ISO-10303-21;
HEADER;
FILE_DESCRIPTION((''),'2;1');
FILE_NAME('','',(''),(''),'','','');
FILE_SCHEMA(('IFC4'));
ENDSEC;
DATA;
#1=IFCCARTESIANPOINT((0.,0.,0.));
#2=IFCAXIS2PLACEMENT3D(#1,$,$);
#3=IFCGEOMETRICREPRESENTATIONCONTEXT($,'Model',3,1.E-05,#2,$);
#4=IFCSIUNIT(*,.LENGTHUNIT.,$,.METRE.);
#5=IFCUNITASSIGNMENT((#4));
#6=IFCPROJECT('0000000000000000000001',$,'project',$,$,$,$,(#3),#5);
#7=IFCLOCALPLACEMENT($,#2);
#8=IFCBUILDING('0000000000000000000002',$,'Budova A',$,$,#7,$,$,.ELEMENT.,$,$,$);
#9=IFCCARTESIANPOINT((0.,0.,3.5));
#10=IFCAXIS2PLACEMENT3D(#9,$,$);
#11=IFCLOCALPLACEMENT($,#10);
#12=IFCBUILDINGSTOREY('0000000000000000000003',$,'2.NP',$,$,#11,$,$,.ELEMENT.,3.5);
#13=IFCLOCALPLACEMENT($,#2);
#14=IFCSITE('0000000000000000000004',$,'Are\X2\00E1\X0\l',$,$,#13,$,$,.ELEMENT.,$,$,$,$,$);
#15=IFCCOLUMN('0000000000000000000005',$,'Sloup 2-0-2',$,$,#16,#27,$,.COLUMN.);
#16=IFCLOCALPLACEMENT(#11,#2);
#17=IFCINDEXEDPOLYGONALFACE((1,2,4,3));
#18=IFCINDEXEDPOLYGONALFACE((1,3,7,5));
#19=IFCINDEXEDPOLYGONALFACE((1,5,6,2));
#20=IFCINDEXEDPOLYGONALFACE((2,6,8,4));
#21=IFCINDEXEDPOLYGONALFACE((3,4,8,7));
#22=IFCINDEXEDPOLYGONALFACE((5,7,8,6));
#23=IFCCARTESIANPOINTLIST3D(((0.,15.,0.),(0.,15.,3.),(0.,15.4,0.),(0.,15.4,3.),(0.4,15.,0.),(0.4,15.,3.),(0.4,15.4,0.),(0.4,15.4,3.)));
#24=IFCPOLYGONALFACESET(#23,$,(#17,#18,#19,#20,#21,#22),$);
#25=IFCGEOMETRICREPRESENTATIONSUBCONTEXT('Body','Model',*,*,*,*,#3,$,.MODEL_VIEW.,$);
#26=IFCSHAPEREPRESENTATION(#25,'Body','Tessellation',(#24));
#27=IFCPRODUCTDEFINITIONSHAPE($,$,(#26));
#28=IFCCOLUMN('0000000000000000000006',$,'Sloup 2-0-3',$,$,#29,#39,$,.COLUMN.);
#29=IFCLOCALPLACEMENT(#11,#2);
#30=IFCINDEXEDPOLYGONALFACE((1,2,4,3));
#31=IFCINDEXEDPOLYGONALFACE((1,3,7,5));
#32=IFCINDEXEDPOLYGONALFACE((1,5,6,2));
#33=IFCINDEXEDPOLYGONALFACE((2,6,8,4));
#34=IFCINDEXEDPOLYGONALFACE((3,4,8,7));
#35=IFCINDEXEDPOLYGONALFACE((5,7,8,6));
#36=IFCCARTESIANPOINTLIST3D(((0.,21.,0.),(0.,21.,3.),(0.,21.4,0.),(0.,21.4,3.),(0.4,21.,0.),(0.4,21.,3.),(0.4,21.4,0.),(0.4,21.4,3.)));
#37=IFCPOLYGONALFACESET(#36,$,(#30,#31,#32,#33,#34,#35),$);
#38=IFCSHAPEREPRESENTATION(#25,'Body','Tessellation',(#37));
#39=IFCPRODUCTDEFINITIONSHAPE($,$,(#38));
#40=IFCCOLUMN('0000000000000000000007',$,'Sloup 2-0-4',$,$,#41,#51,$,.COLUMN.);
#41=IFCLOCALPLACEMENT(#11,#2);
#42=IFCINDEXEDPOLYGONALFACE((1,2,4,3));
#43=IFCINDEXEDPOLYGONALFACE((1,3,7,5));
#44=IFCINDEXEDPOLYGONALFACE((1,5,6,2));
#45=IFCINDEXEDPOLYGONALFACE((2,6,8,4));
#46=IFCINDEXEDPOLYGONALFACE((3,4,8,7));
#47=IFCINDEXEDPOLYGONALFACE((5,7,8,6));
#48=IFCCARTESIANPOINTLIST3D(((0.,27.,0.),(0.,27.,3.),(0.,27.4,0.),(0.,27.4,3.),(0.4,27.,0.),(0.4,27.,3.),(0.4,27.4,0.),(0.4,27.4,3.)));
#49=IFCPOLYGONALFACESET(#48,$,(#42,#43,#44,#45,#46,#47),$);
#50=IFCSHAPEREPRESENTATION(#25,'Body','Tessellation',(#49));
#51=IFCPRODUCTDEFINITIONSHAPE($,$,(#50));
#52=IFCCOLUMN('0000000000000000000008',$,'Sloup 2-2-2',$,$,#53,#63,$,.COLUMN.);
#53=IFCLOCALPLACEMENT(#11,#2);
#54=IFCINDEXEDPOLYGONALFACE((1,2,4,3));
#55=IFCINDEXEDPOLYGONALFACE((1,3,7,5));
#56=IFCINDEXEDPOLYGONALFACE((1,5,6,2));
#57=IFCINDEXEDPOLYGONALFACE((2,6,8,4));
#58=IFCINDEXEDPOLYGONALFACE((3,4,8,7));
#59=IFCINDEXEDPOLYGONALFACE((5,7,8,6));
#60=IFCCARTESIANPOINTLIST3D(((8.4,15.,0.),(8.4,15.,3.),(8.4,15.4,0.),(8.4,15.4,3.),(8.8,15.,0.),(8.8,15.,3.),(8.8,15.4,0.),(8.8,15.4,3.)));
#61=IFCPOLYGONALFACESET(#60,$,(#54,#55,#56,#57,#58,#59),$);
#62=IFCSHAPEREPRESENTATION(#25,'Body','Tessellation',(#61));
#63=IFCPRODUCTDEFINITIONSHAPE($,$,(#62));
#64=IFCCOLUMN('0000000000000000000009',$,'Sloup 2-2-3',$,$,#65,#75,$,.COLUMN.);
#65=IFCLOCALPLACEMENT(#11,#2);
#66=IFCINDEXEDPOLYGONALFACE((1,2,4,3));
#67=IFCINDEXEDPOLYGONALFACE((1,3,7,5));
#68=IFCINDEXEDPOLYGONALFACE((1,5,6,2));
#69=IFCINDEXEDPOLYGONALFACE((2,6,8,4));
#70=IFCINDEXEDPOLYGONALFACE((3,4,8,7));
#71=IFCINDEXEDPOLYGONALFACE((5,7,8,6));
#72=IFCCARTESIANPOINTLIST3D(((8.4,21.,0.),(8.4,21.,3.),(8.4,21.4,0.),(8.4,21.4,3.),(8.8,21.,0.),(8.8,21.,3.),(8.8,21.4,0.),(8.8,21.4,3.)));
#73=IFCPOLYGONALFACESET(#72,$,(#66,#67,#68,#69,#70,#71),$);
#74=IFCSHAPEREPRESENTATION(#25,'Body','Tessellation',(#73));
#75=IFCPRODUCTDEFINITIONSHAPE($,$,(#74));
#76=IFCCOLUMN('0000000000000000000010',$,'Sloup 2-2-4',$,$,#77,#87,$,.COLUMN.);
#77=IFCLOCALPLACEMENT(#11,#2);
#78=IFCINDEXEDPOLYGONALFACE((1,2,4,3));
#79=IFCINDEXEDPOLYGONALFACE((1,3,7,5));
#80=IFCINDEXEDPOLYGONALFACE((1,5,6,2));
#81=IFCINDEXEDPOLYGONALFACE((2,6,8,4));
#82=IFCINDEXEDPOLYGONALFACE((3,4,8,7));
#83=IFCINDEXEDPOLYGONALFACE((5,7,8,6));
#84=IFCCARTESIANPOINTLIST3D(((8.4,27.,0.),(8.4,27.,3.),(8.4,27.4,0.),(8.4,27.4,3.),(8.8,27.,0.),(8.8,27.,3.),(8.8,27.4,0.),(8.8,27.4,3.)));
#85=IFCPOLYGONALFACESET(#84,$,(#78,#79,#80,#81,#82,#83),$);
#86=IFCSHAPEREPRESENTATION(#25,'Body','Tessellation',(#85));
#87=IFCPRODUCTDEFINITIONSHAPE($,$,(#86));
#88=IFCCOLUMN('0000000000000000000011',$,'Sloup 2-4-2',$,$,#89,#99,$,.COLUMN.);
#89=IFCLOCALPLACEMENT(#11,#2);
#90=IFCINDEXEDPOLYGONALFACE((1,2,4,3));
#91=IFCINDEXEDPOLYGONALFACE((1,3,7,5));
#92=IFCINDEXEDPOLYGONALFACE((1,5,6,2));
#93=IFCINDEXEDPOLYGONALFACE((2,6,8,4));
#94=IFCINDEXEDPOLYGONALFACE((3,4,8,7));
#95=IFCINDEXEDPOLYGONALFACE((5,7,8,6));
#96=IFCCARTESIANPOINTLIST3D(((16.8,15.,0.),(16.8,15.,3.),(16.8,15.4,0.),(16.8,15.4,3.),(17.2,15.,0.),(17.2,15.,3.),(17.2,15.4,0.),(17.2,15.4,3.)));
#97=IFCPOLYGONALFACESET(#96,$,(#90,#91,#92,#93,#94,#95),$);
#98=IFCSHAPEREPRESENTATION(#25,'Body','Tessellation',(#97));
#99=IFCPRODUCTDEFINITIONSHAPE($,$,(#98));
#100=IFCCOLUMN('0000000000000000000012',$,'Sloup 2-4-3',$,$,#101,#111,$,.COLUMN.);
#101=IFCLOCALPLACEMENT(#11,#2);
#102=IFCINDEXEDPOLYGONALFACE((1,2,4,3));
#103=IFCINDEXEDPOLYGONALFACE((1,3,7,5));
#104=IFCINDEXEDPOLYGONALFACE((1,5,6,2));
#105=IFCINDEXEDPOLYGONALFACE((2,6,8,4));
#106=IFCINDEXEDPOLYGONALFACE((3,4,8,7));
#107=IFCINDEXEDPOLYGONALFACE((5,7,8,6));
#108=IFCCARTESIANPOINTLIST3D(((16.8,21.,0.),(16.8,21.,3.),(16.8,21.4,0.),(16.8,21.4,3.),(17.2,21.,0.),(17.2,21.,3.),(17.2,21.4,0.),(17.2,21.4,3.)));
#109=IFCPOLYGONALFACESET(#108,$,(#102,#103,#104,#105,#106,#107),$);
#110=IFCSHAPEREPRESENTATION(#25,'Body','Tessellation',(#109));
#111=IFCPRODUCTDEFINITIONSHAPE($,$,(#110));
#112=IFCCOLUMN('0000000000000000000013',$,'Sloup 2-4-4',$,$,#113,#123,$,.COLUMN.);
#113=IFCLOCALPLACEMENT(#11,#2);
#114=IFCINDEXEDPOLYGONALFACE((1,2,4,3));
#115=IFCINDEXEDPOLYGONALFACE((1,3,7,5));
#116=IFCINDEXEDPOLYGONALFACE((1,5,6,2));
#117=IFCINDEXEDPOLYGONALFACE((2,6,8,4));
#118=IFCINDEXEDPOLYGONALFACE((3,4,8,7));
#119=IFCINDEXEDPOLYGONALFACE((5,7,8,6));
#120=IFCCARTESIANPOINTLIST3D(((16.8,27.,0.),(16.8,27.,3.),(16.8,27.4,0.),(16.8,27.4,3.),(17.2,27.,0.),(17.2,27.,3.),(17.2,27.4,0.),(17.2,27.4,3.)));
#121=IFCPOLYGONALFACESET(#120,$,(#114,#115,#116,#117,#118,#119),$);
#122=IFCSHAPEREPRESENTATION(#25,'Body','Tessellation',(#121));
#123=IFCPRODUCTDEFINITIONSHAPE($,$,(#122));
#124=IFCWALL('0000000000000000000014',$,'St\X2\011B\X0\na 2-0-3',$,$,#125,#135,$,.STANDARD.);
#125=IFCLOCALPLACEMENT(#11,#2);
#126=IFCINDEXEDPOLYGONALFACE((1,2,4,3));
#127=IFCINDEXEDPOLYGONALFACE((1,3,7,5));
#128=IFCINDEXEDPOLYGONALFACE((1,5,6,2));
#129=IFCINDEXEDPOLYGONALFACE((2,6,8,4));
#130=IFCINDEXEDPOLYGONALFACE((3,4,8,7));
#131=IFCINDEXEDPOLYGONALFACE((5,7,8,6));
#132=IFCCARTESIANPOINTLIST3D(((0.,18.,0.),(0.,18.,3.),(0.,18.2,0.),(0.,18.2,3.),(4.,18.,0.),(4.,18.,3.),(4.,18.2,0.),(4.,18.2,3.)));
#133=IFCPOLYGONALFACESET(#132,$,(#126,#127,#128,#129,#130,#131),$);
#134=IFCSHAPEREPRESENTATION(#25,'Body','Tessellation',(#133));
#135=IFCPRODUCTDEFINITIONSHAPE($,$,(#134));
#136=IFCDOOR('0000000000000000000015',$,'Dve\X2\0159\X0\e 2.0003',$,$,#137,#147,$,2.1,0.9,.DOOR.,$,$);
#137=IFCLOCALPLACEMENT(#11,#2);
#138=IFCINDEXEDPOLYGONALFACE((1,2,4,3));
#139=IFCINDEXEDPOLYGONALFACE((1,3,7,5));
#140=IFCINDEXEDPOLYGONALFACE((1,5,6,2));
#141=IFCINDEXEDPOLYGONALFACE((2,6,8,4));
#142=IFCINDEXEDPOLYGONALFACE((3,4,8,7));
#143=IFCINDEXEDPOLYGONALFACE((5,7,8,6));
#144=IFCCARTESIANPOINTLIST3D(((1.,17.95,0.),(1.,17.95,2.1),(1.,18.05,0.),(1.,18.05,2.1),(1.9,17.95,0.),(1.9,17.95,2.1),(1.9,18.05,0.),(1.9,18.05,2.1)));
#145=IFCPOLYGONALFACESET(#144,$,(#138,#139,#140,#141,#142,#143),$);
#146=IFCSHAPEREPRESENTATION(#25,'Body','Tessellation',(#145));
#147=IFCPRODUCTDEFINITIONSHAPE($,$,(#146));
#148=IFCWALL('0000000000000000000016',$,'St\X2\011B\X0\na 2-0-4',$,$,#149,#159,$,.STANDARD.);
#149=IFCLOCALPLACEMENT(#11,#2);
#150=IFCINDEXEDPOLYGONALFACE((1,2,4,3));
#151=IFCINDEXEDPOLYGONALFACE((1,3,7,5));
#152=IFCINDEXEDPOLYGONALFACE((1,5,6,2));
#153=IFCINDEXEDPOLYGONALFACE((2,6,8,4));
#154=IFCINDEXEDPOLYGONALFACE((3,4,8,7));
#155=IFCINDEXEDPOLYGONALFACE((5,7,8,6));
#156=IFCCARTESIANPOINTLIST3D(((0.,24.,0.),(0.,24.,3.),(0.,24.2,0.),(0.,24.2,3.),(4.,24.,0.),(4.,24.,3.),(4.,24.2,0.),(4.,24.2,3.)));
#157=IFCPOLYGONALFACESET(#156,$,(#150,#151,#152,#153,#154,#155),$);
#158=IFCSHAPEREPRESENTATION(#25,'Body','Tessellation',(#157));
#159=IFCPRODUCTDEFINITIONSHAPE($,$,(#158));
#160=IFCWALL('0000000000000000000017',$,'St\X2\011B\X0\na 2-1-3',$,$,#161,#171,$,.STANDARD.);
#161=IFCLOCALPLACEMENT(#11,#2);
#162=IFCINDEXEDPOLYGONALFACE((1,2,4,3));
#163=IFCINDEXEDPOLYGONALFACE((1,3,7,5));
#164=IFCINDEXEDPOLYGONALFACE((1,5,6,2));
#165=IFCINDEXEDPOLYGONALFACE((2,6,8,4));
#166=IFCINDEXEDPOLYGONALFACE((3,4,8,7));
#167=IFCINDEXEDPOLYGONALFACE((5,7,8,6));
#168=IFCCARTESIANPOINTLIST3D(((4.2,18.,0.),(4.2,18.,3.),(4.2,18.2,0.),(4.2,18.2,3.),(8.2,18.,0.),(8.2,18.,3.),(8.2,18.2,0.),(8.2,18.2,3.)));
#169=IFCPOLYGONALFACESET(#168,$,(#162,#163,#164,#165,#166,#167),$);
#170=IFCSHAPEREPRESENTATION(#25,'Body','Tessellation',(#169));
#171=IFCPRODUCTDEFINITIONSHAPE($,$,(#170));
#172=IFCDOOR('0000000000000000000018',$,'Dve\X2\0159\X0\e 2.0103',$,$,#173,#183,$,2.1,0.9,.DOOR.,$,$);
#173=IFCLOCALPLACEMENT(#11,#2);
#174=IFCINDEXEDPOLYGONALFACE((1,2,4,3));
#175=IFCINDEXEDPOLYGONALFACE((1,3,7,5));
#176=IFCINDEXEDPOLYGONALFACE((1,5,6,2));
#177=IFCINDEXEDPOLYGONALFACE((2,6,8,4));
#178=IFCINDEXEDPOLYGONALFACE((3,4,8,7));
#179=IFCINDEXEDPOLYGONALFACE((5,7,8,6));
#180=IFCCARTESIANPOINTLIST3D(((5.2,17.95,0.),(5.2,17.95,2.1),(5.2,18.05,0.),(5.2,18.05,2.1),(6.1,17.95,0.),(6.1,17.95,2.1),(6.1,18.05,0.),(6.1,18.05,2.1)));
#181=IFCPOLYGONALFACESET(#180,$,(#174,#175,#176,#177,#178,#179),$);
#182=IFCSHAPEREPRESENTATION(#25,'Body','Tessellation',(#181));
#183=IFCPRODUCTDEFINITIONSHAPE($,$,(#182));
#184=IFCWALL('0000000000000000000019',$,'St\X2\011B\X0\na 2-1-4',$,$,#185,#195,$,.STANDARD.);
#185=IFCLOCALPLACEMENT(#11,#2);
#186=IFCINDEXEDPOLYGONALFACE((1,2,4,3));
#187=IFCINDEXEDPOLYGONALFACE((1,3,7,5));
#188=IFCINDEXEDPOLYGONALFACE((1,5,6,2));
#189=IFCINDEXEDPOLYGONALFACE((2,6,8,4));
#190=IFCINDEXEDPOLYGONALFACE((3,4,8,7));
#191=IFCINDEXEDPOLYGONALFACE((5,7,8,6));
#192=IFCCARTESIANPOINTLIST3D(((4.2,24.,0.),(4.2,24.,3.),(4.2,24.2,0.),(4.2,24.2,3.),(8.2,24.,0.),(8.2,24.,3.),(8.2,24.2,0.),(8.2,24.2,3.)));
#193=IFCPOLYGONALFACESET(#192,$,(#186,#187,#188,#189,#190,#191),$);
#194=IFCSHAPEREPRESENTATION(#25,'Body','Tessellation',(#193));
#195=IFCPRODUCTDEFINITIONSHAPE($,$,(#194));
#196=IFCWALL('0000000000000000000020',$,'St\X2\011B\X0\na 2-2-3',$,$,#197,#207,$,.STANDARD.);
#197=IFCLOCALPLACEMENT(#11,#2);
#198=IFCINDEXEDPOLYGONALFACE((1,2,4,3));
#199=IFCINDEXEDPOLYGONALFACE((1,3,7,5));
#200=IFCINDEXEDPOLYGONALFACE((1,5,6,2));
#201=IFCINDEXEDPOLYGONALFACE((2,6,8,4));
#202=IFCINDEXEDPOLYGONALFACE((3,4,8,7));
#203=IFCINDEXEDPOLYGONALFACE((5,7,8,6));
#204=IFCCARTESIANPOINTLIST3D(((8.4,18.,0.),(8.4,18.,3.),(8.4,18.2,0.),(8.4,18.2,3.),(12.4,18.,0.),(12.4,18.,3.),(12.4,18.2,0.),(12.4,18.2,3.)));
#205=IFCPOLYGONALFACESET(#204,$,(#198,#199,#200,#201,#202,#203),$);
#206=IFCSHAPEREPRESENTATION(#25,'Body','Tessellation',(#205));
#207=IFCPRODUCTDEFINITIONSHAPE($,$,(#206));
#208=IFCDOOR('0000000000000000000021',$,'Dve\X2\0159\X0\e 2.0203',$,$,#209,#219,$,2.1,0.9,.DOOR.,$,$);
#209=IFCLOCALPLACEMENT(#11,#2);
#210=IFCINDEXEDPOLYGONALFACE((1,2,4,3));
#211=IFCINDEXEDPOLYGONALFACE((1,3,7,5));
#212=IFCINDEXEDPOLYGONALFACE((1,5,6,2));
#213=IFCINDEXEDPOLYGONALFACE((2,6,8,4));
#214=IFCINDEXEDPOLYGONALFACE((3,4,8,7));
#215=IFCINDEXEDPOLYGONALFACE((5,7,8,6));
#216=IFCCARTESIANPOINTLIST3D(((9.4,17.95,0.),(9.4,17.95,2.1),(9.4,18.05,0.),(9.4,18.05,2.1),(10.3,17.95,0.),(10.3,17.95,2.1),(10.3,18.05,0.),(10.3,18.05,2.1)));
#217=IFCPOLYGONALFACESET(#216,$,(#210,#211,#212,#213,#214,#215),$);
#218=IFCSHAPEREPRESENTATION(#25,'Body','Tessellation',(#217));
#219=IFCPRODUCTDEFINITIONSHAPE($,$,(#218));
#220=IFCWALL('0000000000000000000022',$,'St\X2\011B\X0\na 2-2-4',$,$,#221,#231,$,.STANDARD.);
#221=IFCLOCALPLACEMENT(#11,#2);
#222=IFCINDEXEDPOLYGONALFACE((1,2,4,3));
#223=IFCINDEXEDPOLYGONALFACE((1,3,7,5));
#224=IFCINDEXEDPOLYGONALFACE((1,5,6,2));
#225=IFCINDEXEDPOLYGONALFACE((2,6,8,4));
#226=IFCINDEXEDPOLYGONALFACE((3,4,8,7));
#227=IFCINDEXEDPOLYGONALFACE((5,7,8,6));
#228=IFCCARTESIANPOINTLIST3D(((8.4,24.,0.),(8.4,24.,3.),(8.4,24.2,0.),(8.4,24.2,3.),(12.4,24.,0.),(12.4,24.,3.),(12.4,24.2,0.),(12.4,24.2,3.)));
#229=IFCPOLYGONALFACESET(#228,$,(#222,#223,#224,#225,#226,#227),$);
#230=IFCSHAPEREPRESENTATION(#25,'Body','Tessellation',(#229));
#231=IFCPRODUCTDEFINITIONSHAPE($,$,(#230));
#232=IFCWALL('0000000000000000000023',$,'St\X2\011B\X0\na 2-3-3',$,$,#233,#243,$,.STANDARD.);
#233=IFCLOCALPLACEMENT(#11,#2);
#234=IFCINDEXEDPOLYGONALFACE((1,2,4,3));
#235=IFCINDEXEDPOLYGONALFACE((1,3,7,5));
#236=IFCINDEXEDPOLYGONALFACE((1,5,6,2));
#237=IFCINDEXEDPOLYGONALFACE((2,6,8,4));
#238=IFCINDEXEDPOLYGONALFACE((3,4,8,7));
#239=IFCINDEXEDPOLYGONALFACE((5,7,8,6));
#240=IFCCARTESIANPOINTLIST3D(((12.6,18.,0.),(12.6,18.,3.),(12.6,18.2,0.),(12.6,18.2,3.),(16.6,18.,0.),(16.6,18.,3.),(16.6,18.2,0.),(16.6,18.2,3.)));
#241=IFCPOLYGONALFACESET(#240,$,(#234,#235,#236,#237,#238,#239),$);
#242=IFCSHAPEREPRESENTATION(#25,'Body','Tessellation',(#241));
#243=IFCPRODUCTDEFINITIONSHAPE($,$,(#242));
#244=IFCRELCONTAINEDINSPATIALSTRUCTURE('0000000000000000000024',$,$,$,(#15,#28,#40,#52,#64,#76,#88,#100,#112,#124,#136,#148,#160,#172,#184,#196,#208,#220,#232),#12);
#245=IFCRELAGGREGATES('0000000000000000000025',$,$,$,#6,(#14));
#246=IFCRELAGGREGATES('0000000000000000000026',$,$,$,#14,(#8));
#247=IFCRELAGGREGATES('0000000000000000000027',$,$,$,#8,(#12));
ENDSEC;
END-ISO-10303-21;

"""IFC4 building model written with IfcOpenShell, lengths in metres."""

from ifc_helpers import new_model, si_unit, frame, frame_2d, origin, place, context, subcontext, project, spatial, rectangle, extrude, element, save


model = new_model("IFC4")

# Units and contexts
model_context = context("Model", 3, precision=1e-05, world=origin())
body_context = subcontext(model_context, "Body", "Model", "MODEL_VIEW")
ifc_project = project(units=[si_unit("LENGTHUNIT", "METRE")], contexts=[model_context])

# Site, building, storey
site_placement = place(None, origin())
site = spatial("IfcSite", under=ifc_project, at=site_placement, Name="Areál", CompositionType="ELEMENT")
building_placement = place(None, origin())
building = spatial("IfcBuilding", under=site, at=building_placement, Name="Budova A", CompositionType="ELEMENT")
storey_placement = place(None, frame((0.0, 0.0, 3.5)))
storey = spatial("IfcBuildingStorey", under=building, at=storey_placement, Name="2.NP", CompositionType="ELEMENT", Elevation=3.5)

# Columns
for number, where, name in (
    (1, (0.0, 15.0, 0.0), "Sloup 2-0-2"),
    (2, (0.0, 21.0, 0.0), "Sloup 2-0-3"),
    (3, (0.0, 27.0, 0.0), "Sloup 2-0-4"),
    (4, (8.4, 15.0, 0.0), "Sloup 2-2-2"),
    (5, (8.4, 21.0, 0.0), "Sloup 2-2-3"),
    (6, (8.4, 27.0, 0.0), "Sloup 2-2-4"),
    (7, (16.8, 15.0, 0.0), "Sloup 2-4-2"),
    (8, (16.8, 21.0, 0.0), "Sloup 2-4-3"),
    (9, (16.8, 27.0, 0.0), "Sloup 2-4-4"),
):
    element("IfcColumn", number, at=place(storey_placement, frame(where)), inside=storey, Name=name, PredefinedType="COLUMN", context=body_context, shape_type="SweptSolid", body=[
        extrude(rectangle(XDim=0.4, YDim=0.4, at=frame_2d((0.2, 0.2))), origin(), (0.0, 0.0, 1.0), 3.0),
    ])

# Wall
wall_1_placement = place(storey_placement, frame((0.0, 18.0, 0.0)))
element("IfcWall", 10, at=wall_1_placement, inside=storey, Name="Stěna 2-0-3", PredefinedType="STANDARD", context=body_context, shape_type="SweptSolid", body=[
    extrude(rectangle(XDim=4.0, YDim=0.2, at=frame_2d((2.0, 0.1))), origin(), (0.0, 0.0, 1.0), 3.0),
])

# Door
door_1_placement = place(storey_placement, frame((1.0, 17.95, 0.0)))
element("IfcDoor", 11, at=door_1_placement, inside=storey, Name="Dveře 2.0003", OverallHeight=2.1, OverallWidth=0.9, PredefinedType="DOOR", context=body_context, shape_type="SweptSolid", body=[
    extrude(rectangle(XDim=0.9, YDim=0.1, at=frame_2d((0.45, 0.05))), origin(), (0.0, 0.0, 1.0), 2.1),
])

# Walls
for number, where, name in (
    (12, (0.0, 24.0, 0.0), "Stěna 2-0-4"),
    (13, (4.2, 18.0, 0.0), "Stěna 2-1-3"),
):
    element("IfcWall", number, at=place(storey_placement, frame(where)), inside=storey, Name=name, PredefinedType="STANDARD", context=body_context, shape_type="SweptSolid", body=[
        extrude(rectangle(XDim=4.0, YDim=0.2, at=frame_2d((2.0, 0.1))), origin(), (0.0, 0.0, 1.0), 3.0),
    ])

# Door
door_2_placement = place(storey_placement, frame((5.2, 17.95, 0.0)))
element("IfcDoor", 14, at=door_2_placement, inside=storey, Name="Dveře 2.0103", OverallHeight=2.1, OverallWidth=0.9, PredefinedType="DOOR", context=body_context, shape_type="SweptSolid", body=[
    extrude(rectangle(XDim=0.9, YDim=0.1, at=frame_2d((0.45, 0.05))), origin(), (0.0, 0.0, 1.0), 2.1),
])

# Walls
for number, where, name in (
    (15, (4.2, 24.0, 0.0), "Stěna 2-1-4"),
    (16, (8.4, 18.0, 0.0), "Stěna 2-2-3"),
):
    element("IfcWall", number, at=place(storey_placement, frame(where)), inside=storey, Name=name, PredefinedType="STANDARD", context=body_context, shape_type="SweptSolid", body=[
        extrude(rectangle(XDim=4.0, YDim=0.2, at=frame_2d((2.0, 0.1))), origin(), (0.0, 0.0, 1.0), 3.0),
    ])

# Door
door_3_placement = place(storey_placement, frame((9.4, 17.95, 0.0)))
element("IfcDoor", 17, at=door_3_placement, inside=storey, Name="Dveře 2.0203", OverallHeight=2.1, OverallWidth=0.9, PredefinedType="DOOR", context=body_context, shape_type="SweptSolid", body=[
    extrude(rectangle(XDim=0.9, YDim=0.1, at=frame_2d((0.45, 0.05))), origin(), (0.0, 0.0, 1.0), 2.1),
])

# Walls
for number, where, name in (
    (18, (8.4, 24.0, 0.0), "Stěna 2-2-4"),
    (19, (12.6, 18.0, 0.0), "Stěna 2-3-3"),
):
    element("IfcWall", number, at=place(storey_placement, frame(where)), inside=storey, Name=name, PredefinedType="STANDARD", context=body_context, shape_type="SweptSolid", body=[
        extrude(rectangle(XDim=4.0, YDim=0.2, at=frame_2d((2.0, 0.1))), origin(), (0.0, 0.0, 1.0), 3.0),
    ])

save(model, "model.ifc")
